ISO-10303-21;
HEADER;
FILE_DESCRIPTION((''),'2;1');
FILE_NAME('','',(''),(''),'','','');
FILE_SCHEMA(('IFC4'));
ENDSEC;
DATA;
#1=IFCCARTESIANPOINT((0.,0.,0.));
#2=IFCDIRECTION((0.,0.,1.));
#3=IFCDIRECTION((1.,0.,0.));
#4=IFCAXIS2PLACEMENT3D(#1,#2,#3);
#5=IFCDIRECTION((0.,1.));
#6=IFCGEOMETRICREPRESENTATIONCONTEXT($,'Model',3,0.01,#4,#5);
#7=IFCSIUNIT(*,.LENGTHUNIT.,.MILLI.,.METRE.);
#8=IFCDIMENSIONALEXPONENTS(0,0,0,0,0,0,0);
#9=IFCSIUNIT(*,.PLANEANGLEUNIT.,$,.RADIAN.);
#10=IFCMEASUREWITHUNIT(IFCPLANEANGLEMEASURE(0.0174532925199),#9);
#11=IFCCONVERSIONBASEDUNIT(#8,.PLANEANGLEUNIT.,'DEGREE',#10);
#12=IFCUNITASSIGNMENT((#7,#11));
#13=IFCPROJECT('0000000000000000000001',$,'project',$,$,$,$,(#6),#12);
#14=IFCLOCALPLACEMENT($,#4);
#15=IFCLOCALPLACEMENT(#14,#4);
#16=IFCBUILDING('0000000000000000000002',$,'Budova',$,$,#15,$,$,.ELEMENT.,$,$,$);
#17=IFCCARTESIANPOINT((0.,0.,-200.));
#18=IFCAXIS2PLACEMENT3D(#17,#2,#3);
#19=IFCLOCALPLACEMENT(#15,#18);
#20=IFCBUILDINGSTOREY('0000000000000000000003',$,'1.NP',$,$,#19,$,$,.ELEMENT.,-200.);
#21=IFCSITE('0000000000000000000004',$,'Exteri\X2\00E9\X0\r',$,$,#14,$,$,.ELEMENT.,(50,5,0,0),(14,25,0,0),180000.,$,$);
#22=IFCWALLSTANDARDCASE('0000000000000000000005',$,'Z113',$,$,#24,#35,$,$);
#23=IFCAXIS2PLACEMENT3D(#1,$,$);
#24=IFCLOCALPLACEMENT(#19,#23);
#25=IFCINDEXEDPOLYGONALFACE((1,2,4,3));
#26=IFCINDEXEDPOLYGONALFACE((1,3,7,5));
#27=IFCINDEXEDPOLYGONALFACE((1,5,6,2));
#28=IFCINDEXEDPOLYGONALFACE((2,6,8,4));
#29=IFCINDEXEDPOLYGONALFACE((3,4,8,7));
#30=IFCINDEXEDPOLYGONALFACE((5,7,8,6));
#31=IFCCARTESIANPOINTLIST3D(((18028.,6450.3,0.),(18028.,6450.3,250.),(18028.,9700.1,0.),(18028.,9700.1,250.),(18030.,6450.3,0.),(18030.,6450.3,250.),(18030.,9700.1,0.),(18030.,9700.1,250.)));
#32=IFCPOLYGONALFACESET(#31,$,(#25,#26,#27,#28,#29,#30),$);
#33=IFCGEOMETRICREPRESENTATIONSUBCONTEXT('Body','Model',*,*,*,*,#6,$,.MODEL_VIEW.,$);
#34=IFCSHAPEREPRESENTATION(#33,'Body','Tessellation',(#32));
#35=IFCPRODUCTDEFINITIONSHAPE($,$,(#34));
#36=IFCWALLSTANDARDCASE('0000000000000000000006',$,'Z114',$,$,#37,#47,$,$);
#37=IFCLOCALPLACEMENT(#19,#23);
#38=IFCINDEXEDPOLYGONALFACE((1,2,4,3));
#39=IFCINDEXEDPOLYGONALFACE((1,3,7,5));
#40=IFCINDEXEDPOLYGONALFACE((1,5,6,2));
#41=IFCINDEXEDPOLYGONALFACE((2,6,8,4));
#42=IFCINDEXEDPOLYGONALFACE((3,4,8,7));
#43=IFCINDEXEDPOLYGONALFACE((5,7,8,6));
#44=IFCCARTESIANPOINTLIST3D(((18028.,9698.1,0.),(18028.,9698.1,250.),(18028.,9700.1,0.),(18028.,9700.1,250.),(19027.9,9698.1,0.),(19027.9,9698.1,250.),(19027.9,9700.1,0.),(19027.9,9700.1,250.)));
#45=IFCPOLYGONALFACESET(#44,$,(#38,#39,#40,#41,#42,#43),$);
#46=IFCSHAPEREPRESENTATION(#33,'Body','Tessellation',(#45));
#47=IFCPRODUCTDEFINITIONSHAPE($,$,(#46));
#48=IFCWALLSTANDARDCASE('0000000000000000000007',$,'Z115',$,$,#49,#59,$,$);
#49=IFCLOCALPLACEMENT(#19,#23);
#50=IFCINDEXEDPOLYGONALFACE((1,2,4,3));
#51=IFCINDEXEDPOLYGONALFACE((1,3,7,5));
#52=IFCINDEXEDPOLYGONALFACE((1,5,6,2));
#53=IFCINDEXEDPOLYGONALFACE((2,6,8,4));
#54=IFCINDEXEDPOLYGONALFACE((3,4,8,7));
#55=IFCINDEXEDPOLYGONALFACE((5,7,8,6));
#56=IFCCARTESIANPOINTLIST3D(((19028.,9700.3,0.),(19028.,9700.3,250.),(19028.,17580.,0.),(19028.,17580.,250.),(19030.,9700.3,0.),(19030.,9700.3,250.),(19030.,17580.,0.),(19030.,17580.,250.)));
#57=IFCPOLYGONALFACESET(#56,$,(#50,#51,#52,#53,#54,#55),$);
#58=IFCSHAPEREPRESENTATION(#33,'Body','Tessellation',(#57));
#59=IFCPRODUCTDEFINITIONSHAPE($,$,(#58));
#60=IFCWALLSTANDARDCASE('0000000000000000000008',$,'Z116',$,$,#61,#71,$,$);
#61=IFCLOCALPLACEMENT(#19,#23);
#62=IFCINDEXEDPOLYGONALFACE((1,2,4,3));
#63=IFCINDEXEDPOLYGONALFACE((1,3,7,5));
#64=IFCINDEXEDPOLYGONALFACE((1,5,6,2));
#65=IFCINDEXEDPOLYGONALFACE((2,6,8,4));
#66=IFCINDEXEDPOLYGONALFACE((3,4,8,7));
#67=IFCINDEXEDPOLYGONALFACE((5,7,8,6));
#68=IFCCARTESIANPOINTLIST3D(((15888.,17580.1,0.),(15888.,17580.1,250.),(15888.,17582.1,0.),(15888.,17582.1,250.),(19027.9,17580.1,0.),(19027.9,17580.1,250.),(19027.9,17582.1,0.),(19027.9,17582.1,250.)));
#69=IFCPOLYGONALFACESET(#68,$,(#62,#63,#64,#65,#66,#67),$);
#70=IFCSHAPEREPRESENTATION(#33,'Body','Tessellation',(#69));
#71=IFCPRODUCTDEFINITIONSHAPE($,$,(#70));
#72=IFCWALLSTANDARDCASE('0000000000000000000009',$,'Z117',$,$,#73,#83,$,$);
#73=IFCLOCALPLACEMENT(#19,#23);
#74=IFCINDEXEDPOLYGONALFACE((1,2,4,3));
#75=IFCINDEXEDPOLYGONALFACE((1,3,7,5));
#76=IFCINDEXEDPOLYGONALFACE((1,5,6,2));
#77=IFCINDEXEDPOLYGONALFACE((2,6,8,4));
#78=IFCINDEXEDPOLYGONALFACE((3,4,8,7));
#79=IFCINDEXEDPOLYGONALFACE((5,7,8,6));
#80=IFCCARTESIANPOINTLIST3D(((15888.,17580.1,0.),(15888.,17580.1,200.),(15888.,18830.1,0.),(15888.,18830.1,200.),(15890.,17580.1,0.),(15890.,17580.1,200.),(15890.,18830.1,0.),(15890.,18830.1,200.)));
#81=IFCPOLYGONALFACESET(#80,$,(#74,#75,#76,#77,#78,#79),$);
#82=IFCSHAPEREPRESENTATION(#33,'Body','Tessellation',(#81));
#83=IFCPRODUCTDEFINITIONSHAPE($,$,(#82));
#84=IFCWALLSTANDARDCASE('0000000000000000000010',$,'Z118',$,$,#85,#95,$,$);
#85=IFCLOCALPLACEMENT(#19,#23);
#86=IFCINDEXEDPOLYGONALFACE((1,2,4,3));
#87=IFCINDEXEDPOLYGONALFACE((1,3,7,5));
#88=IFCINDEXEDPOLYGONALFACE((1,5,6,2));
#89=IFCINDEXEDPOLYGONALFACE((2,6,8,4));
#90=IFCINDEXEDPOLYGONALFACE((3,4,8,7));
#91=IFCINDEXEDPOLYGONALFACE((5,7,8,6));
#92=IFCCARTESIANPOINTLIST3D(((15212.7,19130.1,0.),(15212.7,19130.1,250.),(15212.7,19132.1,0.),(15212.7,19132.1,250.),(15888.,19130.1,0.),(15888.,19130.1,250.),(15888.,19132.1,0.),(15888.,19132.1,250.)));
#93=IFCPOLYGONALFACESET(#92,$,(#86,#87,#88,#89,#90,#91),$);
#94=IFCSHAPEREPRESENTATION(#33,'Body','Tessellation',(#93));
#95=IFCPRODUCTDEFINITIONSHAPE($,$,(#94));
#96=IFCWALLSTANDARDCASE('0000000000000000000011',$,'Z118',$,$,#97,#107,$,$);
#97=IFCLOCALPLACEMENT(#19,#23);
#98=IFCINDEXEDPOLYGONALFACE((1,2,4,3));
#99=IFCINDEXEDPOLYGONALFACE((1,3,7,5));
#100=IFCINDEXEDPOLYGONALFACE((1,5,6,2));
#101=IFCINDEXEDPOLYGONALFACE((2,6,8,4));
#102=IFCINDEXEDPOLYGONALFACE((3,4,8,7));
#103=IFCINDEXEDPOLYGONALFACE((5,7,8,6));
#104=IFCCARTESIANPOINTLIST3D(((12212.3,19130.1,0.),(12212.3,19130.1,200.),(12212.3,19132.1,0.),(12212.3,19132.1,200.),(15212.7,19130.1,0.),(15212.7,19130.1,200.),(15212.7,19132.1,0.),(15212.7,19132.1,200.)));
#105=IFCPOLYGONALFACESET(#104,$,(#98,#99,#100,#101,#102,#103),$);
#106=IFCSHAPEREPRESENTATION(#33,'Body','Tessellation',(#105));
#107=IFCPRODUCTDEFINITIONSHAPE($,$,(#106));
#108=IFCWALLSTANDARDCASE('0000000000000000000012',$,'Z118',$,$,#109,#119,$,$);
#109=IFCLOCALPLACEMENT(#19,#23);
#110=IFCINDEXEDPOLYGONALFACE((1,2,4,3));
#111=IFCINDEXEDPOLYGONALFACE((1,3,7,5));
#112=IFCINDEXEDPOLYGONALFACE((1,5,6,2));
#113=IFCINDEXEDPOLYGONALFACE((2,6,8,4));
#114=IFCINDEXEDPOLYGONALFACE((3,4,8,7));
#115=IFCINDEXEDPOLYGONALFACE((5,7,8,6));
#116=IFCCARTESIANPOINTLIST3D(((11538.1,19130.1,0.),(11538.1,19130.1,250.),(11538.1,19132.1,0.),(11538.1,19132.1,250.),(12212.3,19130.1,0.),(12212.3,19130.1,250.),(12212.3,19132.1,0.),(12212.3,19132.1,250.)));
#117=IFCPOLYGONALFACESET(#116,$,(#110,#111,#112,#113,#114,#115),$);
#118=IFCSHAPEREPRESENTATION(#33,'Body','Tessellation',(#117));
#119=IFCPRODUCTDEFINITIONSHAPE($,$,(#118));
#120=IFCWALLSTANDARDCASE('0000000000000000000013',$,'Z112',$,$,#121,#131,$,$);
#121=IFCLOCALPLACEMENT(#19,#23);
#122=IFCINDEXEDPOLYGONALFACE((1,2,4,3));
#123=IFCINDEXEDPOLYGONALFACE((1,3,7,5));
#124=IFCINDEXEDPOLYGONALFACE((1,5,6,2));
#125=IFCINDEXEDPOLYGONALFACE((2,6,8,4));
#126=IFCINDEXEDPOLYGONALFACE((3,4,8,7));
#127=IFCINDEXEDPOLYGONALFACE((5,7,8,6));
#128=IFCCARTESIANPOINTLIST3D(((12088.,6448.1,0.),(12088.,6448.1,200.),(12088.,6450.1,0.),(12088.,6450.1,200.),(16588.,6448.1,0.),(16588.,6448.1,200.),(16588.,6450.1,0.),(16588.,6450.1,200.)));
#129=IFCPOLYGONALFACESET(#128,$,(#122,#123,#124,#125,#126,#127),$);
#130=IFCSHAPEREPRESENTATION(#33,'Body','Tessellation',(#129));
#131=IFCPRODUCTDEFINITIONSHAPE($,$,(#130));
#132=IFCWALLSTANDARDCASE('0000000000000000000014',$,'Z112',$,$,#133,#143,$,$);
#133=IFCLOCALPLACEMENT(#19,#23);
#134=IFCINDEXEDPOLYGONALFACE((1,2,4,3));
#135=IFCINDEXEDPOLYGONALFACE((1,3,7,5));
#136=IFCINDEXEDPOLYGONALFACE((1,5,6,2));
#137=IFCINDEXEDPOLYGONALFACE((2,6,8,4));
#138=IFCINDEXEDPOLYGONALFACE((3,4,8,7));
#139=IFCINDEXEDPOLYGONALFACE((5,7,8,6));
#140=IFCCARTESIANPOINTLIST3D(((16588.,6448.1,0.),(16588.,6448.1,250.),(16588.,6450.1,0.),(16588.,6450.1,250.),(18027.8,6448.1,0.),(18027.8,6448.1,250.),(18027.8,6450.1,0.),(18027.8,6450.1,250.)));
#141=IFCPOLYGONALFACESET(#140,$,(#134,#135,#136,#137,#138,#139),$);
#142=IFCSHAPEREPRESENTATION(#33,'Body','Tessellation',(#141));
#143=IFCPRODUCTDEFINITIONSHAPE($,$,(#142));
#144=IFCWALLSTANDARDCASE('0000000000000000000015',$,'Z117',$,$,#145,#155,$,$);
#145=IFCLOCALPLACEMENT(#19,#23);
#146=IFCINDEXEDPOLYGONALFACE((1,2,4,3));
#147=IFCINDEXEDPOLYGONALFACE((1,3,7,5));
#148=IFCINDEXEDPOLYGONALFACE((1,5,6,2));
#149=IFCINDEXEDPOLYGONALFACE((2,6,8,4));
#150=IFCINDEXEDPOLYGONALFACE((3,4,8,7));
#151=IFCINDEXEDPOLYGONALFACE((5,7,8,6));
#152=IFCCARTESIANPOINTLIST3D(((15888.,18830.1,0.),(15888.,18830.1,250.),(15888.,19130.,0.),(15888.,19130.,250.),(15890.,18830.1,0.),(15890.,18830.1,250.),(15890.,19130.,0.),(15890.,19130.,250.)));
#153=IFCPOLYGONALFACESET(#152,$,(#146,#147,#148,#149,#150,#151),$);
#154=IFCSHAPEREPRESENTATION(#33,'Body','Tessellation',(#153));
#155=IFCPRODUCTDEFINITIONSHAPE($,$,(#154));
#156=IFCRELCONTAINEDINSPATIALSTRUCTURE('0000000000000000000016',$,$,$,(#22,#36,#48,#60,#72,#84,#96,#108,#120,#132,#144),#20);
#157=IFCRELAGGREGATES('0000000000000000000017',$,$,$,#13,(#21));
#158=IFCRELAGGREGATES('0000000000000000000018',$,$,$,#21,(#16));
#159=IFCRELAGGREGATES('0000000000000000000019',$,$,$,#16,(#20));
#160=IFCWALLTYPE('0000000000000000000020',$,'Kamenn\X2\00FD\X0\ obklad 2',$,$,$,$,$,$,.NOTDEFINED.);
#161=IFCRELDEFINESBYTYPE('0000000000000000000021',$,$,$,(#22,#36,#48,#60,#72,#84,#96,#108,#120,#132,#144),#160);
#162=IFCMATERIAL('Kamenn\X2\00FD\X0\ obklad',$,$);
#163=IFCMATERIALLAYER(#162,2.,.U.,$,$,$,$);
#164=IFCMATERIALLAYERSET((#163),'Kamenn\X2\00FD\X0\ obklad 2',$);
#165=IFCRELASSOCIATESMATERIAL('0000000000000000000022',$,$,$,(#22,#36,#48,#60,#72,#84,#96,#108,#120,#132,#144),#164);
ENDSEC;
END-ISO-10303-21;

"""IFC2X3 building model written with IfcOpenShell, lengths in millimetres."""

from ifc_helpers import new_model, entity, si_unit, converted_unit, direction, frame, origin_with_axes, place, context, subcontext, project, spatial, polyline, outline, extrude, material, layer, layer_set, layer_usage, type_object, element, save


model = new_model("IFC2X3")

# Units and contexts
model_context = context("Model", 3, precision=0.01, world=origin_with_axes(), true_north=direction((0.0, 1.0)))
body_context = subcontext(model_context, "Body", "Model", "MODEL_VIEW")
ifc_project = project(units=[si_unit("LENGTHUNIT", "METRE", prefix="MILLI"), converted_unit("PLANEANGLEUNIT", "DEGREE", entity("IfcPlaneAngleMeasure", 0.0174532925199), si_unit("PLANEANGLEUNIT", "RADIAN"), dimensions=[0, 0, 0, 0, 0, 0, 0])], contexts=[model_context])

# Site, building, storey
site_placement = place(None, origin_with_axes())
site = spatial("IfcSite", under=ifc_project, at=site_placement, Name="Exteriér", CompositionType="ELEMENT", RefLatitude=(50, 5, 0, 0), RefLongitude=(14, 25, 0, 0), RefElevation=180000.0)
building_placement = place(site_placement, origin_with_axes())
building = spatial("IfcBuilding", under=site, at=building_placement, Name="Budova", CompositionType="ELEMENT")
storey_placement = place(building_placement, frame((0.0, 0.0, -200.0), z_axis=(0.0, 0.0, 1.0), x_axis=(1.0, 0.0, 0.0)))
storey = spatial("IfcBuildingStorey", under=building, at=storey_placement, Name="1.NP", CompositionType="ELEMENT", Elevation=-200.0)

# Walls
ifc_material_1 = material(Name="Kamenný obklad")
ifc_layer_1 = layer(ifc_material_1, 2.0, ventilated="UNKNOWN")
ifc_layer_set_1 = layer_set([ifc_layer_1], Name="Kamenný obklad 2")
wall_type_1 = type_object("IfcWallType", Name="Kamenný obklad 2", PredefinedType="NOTDEFINED")
ifc_layer_usage_1 = layer_usage(ifc_layer_set_1, "AXIS2", "POSITIVE", -2.0)
wall_1_placement = place(storey_placement, frame((18028.0, 6450.3, 0.0), z_axis=(0.0, 0.0, 1.0), x_axis=(0.0, 1.0, 0.0)))
element("IfcWallStandardCase", 1, at=wall_1_placement, inside=storey, type_object=wall_type_1, material=ifc_layer_usage_1, Name="Z113", context=body_context, shape_type="SweptSolid", body=[
    extrude(outline(polyline([(0.0, -2.0), (3249.9, -2.0), (3249.9, 0.0), (0.0, 0.0), (0.0, -2.0)])), origin_with_axes(), (0.0, 0.0, 1.0), 250.0),
])
ifc_layer_usage_2 = layer_usage(ifc_layer_set_1, "AXIS2", "POSITIVE", -2.0)
wall_2_placement = place(storey_placement, frame((18028.0, 9700.1, 0.0), z_axis=(0.0, 0.0, 1.0), x_axis=(1.0, 0.0, 0.0)))
element("IfcWallStandardCase", 2, at=wall_2_placement, inside=storey, type_object=wall_type_1, material=ifc_layer_usage_2, Name="Z114", context=body_context, shape_type="SweptSolid", body=[
    extrude(outline(polyline([(0.0, -2.0), (999.9, -2.0), (999.9, 0.0), (0.0, 0.0), (0.0, -2.0)])), origin_with_axes(), (0.0, 0.0, 1.0), 250.0),
])
ifc_layer_usage_3 = layer_usage(ifc_layer_set_1, "AXIS2", "POSITIVE", -2.0)
wall_3_placement = place(storey_placement, frame((19028.0, 9700.3, 0.0), z_axis=(0.0, 0.0, 1.0), x_axis=(0.0, 1.0, 0.0)))
element("IfcWallStandardCase", 3, at=wall_3_placement, inside=storey, type_object=wall_type_1, material=ifc_layer_usage_3, Name="Z115", context=body_context, shape_type="SweptSolid", body=[
    extrude(outline(polyline([(0.0, -2.0), (7879.8, -2.0), (7879.8, 0.0), (0.0, 0.0), (0.0, -2.0)])), origin_with_axes(), (0.0, 0.0, 1.0), 250.0),
])
ifc_layer_usage_4 = layer_usage(ifc_layer_set_1, "AXIS2", "POSITIVE", -2.0)
wall_4_placement = place(storey_placement, frame((19027.9, 17580.1, 0.0), z_axis=(0.0, 0.0, 1.0), x_axis=(-1.0, 0.0, 0.0)))
element("IfcWallStandardCase", 4, at=wall_4_placement, inside=storey, type_object=wall_type_1, material=ifc_layer_usage_4, Name="Z116", context=body_context, shape_type="SweptSolid", body=[
    extrude(outline(polyline([(0.0, -2.0), (3139.9, -2.0), (3139.9, 0.0), (0.0, 0.0), (0.0, -2.0)])), origin_with_axes(), (0.0, 0.0, 1.0), 250.0),
])
ifc_layer_usage_5 = layer_usage(ifc_layer_set_1, "AXIS2", "POSITIVE", -2.0)
wall_5_placement = place(storey_placement, frame((15888.0, 17580.1, 0.0), z_axis=(0.0, 0.0, 1.0), x_axis=(0.0, 1.0, 0.0)))
element("IfcWallStandardCase", 5, at=wall_5_placement, inside=storey, type_object=wall_type_1, material=ifc_layer_usage_5, Name="Z117", context=body_context, shape_type="SweptSolid", body=[
    extrude(outline(polyline([(0.0, -2.0), (1250.0, -2.0), (1250.0, 0.0), (0.0, 0.0), (0.0, -2.0)])), origin_with_axes(), (0.0, 0.0, 1.0), 200.0),
])
ifc_layer_usage_6 = layer_usage(ifc_layer_set_1, "AXIS2", "POSITIVE", -2.0)
wall_6_placement = place(storey_placement, frame((15888.0, 19130.1, 0.0), z_axis=(0.0, 0.0, 1.0), x_axis=(-1.0, 0.0, 0.0)))
element("IfcWallStandardCase", 6, at=wall_6_placement, inside=storey, type_object=wall_type_1, material=ifc_layer_usage_6, Name="Z118", context=body_context, shape_type="SweptSolid", body=[
    extrude(outline(polyline([(0.0, -2.0), (675.3, -2.0), (675.3, 0.0), (0.0, 0.0), (0.0, -2.0)])), origin_with_axes(), (0.0, 0.0, 1.0), 250.0),
])
ifc_layer_usage_7 = layer_usage(ifc_layer_set_1, "AXIS2", "POSITIVE", -2.0)
wall_7_placement = place(storey_placement, frame((15212.7, 19130.1, 0.0), z_axis=(0.0, 0.0, 1.0), x_axis=(-1.0, 0.0, 0.0)))
element("IfcWallStandardCase", 7, at=wall_7_placement, inside=storey, type_object=wall_type_1, material=ifc_layer_usage_7, Name="Z118", context=body_context, shape_type="SweptSolid", body=[
    extrude(outline(polyline([(0.0, -2.0), (3000.4, -2.0), (3000.4, 0.0), (0.0, 0.0), (0.0, -2.0)])), origin_with_axes(), (0.0, 0.0, 1.0), 200.0),
])
ifc_layer_usage_8 = layer_usage(ifc_layer_set_1, "AXIS2", "POSITIVE", -2.0)
wall_8_placement = place(storey_placement, frame((12212.3, 19130.1, 0.0), z_axis=(0.0, 0.0, 1.0), x_axis=(-1.0, 0.0, 0.0)))
element("IfcWallStandardCase", 8, at=wall_8_placement, inside=storey, type_object=wall_type_1, material=ifc_layer_usage_8, Name="Z118", context=body_context, shape_type="SweptSolid", body=[
    extrude(outline(polyline([(0.0, -2.0), (674.2, -2.0), (674.2, 0.0), (0.0, 0.0), (0.0, -2.0)])), origin_with_axes(), (0.0, 0.0, 1.0), 250.0),
])
ifc_layer_usage_9 = layer_usage(ifc_layer_set_1, "AXIS2", "POSITIVE", -2.0)
wall_9_placement = place(storey_placement, frame((12088.0, 6450.1, 0.0), z_axis=(0.0, 0.0, 1.0), x_axis=(1.0, 0.0, 0.0)))
element("IfcWallStandardCase", 9, at=wall_9_placement, inside=storey, type_object=wall_type_1, material=ifc_layer_usage_9, Name="Z112", context=body_context, shape_type="SweptSolid", body=[
    extrude(outline(polyline([(0.0, -2.0), (4500.0, -2.0), (4500.0, 0.0), (0.0, 0.0), (0.0, -2.0)])), origin_with_axes(), (0.0, 0.0, 1.0), 200.0),
])
ifc_layer_usage_10 = layer_usage(ifc_layer_set_1, "AXIS2", "POSITIVE", -2.0)
wall_10_placement = place(storey_placement, frame((16588.0, 6450.1, 0.0), z_axis=(0.0, 0.0, 1.0), x_axis=(1.0, 0.0, 0.0)))
element("IfcWallStandardCase", 10, at=wall_10_placement, inside=storey, type_object=wall_type_1, material=ifc_layer_usage_10, Name="Z112", context=body_context, shape_type="SweptSolid", body=[
    extrude(outline(polyline([(0.0, -2.0), (1439.8, -2.0), (1439.8, 0.0), (0.0, 0.0), (0.0, -2.0)])), origin_with_axes(), (0.0, 0.0, 1.0), 250.0),
])
ifc_layer_usage_11 = layer_usage(ifc_layer_set_1, "AXIS2", "POSITIVE", -2.0)
wall_11_placement = place(storey_placement, frame((15888.0, 18830.1, 0.0), z_axis=(0.0, 0.0, 1.0), x_axis=(0.0, 1.0, 0.0)))
element("IfcWallStandardCase", 11, at=wall_11_placement, inside=storey, type_object=wall_type_1, material=ifc_layer_usage_11, Name="Z117", context=body_context, shape_type="SweptSolid", body=[
    extrude(outline(polyline([(0.0, -2.0), (299.9, -2.0), (299.9, 0.0), (0.0, 0.0), (0.0, -2.0)])), origin_with_axes(), (0.0, 0.0, 1.0), 250.0),
])

save(model, "model.ifc")
